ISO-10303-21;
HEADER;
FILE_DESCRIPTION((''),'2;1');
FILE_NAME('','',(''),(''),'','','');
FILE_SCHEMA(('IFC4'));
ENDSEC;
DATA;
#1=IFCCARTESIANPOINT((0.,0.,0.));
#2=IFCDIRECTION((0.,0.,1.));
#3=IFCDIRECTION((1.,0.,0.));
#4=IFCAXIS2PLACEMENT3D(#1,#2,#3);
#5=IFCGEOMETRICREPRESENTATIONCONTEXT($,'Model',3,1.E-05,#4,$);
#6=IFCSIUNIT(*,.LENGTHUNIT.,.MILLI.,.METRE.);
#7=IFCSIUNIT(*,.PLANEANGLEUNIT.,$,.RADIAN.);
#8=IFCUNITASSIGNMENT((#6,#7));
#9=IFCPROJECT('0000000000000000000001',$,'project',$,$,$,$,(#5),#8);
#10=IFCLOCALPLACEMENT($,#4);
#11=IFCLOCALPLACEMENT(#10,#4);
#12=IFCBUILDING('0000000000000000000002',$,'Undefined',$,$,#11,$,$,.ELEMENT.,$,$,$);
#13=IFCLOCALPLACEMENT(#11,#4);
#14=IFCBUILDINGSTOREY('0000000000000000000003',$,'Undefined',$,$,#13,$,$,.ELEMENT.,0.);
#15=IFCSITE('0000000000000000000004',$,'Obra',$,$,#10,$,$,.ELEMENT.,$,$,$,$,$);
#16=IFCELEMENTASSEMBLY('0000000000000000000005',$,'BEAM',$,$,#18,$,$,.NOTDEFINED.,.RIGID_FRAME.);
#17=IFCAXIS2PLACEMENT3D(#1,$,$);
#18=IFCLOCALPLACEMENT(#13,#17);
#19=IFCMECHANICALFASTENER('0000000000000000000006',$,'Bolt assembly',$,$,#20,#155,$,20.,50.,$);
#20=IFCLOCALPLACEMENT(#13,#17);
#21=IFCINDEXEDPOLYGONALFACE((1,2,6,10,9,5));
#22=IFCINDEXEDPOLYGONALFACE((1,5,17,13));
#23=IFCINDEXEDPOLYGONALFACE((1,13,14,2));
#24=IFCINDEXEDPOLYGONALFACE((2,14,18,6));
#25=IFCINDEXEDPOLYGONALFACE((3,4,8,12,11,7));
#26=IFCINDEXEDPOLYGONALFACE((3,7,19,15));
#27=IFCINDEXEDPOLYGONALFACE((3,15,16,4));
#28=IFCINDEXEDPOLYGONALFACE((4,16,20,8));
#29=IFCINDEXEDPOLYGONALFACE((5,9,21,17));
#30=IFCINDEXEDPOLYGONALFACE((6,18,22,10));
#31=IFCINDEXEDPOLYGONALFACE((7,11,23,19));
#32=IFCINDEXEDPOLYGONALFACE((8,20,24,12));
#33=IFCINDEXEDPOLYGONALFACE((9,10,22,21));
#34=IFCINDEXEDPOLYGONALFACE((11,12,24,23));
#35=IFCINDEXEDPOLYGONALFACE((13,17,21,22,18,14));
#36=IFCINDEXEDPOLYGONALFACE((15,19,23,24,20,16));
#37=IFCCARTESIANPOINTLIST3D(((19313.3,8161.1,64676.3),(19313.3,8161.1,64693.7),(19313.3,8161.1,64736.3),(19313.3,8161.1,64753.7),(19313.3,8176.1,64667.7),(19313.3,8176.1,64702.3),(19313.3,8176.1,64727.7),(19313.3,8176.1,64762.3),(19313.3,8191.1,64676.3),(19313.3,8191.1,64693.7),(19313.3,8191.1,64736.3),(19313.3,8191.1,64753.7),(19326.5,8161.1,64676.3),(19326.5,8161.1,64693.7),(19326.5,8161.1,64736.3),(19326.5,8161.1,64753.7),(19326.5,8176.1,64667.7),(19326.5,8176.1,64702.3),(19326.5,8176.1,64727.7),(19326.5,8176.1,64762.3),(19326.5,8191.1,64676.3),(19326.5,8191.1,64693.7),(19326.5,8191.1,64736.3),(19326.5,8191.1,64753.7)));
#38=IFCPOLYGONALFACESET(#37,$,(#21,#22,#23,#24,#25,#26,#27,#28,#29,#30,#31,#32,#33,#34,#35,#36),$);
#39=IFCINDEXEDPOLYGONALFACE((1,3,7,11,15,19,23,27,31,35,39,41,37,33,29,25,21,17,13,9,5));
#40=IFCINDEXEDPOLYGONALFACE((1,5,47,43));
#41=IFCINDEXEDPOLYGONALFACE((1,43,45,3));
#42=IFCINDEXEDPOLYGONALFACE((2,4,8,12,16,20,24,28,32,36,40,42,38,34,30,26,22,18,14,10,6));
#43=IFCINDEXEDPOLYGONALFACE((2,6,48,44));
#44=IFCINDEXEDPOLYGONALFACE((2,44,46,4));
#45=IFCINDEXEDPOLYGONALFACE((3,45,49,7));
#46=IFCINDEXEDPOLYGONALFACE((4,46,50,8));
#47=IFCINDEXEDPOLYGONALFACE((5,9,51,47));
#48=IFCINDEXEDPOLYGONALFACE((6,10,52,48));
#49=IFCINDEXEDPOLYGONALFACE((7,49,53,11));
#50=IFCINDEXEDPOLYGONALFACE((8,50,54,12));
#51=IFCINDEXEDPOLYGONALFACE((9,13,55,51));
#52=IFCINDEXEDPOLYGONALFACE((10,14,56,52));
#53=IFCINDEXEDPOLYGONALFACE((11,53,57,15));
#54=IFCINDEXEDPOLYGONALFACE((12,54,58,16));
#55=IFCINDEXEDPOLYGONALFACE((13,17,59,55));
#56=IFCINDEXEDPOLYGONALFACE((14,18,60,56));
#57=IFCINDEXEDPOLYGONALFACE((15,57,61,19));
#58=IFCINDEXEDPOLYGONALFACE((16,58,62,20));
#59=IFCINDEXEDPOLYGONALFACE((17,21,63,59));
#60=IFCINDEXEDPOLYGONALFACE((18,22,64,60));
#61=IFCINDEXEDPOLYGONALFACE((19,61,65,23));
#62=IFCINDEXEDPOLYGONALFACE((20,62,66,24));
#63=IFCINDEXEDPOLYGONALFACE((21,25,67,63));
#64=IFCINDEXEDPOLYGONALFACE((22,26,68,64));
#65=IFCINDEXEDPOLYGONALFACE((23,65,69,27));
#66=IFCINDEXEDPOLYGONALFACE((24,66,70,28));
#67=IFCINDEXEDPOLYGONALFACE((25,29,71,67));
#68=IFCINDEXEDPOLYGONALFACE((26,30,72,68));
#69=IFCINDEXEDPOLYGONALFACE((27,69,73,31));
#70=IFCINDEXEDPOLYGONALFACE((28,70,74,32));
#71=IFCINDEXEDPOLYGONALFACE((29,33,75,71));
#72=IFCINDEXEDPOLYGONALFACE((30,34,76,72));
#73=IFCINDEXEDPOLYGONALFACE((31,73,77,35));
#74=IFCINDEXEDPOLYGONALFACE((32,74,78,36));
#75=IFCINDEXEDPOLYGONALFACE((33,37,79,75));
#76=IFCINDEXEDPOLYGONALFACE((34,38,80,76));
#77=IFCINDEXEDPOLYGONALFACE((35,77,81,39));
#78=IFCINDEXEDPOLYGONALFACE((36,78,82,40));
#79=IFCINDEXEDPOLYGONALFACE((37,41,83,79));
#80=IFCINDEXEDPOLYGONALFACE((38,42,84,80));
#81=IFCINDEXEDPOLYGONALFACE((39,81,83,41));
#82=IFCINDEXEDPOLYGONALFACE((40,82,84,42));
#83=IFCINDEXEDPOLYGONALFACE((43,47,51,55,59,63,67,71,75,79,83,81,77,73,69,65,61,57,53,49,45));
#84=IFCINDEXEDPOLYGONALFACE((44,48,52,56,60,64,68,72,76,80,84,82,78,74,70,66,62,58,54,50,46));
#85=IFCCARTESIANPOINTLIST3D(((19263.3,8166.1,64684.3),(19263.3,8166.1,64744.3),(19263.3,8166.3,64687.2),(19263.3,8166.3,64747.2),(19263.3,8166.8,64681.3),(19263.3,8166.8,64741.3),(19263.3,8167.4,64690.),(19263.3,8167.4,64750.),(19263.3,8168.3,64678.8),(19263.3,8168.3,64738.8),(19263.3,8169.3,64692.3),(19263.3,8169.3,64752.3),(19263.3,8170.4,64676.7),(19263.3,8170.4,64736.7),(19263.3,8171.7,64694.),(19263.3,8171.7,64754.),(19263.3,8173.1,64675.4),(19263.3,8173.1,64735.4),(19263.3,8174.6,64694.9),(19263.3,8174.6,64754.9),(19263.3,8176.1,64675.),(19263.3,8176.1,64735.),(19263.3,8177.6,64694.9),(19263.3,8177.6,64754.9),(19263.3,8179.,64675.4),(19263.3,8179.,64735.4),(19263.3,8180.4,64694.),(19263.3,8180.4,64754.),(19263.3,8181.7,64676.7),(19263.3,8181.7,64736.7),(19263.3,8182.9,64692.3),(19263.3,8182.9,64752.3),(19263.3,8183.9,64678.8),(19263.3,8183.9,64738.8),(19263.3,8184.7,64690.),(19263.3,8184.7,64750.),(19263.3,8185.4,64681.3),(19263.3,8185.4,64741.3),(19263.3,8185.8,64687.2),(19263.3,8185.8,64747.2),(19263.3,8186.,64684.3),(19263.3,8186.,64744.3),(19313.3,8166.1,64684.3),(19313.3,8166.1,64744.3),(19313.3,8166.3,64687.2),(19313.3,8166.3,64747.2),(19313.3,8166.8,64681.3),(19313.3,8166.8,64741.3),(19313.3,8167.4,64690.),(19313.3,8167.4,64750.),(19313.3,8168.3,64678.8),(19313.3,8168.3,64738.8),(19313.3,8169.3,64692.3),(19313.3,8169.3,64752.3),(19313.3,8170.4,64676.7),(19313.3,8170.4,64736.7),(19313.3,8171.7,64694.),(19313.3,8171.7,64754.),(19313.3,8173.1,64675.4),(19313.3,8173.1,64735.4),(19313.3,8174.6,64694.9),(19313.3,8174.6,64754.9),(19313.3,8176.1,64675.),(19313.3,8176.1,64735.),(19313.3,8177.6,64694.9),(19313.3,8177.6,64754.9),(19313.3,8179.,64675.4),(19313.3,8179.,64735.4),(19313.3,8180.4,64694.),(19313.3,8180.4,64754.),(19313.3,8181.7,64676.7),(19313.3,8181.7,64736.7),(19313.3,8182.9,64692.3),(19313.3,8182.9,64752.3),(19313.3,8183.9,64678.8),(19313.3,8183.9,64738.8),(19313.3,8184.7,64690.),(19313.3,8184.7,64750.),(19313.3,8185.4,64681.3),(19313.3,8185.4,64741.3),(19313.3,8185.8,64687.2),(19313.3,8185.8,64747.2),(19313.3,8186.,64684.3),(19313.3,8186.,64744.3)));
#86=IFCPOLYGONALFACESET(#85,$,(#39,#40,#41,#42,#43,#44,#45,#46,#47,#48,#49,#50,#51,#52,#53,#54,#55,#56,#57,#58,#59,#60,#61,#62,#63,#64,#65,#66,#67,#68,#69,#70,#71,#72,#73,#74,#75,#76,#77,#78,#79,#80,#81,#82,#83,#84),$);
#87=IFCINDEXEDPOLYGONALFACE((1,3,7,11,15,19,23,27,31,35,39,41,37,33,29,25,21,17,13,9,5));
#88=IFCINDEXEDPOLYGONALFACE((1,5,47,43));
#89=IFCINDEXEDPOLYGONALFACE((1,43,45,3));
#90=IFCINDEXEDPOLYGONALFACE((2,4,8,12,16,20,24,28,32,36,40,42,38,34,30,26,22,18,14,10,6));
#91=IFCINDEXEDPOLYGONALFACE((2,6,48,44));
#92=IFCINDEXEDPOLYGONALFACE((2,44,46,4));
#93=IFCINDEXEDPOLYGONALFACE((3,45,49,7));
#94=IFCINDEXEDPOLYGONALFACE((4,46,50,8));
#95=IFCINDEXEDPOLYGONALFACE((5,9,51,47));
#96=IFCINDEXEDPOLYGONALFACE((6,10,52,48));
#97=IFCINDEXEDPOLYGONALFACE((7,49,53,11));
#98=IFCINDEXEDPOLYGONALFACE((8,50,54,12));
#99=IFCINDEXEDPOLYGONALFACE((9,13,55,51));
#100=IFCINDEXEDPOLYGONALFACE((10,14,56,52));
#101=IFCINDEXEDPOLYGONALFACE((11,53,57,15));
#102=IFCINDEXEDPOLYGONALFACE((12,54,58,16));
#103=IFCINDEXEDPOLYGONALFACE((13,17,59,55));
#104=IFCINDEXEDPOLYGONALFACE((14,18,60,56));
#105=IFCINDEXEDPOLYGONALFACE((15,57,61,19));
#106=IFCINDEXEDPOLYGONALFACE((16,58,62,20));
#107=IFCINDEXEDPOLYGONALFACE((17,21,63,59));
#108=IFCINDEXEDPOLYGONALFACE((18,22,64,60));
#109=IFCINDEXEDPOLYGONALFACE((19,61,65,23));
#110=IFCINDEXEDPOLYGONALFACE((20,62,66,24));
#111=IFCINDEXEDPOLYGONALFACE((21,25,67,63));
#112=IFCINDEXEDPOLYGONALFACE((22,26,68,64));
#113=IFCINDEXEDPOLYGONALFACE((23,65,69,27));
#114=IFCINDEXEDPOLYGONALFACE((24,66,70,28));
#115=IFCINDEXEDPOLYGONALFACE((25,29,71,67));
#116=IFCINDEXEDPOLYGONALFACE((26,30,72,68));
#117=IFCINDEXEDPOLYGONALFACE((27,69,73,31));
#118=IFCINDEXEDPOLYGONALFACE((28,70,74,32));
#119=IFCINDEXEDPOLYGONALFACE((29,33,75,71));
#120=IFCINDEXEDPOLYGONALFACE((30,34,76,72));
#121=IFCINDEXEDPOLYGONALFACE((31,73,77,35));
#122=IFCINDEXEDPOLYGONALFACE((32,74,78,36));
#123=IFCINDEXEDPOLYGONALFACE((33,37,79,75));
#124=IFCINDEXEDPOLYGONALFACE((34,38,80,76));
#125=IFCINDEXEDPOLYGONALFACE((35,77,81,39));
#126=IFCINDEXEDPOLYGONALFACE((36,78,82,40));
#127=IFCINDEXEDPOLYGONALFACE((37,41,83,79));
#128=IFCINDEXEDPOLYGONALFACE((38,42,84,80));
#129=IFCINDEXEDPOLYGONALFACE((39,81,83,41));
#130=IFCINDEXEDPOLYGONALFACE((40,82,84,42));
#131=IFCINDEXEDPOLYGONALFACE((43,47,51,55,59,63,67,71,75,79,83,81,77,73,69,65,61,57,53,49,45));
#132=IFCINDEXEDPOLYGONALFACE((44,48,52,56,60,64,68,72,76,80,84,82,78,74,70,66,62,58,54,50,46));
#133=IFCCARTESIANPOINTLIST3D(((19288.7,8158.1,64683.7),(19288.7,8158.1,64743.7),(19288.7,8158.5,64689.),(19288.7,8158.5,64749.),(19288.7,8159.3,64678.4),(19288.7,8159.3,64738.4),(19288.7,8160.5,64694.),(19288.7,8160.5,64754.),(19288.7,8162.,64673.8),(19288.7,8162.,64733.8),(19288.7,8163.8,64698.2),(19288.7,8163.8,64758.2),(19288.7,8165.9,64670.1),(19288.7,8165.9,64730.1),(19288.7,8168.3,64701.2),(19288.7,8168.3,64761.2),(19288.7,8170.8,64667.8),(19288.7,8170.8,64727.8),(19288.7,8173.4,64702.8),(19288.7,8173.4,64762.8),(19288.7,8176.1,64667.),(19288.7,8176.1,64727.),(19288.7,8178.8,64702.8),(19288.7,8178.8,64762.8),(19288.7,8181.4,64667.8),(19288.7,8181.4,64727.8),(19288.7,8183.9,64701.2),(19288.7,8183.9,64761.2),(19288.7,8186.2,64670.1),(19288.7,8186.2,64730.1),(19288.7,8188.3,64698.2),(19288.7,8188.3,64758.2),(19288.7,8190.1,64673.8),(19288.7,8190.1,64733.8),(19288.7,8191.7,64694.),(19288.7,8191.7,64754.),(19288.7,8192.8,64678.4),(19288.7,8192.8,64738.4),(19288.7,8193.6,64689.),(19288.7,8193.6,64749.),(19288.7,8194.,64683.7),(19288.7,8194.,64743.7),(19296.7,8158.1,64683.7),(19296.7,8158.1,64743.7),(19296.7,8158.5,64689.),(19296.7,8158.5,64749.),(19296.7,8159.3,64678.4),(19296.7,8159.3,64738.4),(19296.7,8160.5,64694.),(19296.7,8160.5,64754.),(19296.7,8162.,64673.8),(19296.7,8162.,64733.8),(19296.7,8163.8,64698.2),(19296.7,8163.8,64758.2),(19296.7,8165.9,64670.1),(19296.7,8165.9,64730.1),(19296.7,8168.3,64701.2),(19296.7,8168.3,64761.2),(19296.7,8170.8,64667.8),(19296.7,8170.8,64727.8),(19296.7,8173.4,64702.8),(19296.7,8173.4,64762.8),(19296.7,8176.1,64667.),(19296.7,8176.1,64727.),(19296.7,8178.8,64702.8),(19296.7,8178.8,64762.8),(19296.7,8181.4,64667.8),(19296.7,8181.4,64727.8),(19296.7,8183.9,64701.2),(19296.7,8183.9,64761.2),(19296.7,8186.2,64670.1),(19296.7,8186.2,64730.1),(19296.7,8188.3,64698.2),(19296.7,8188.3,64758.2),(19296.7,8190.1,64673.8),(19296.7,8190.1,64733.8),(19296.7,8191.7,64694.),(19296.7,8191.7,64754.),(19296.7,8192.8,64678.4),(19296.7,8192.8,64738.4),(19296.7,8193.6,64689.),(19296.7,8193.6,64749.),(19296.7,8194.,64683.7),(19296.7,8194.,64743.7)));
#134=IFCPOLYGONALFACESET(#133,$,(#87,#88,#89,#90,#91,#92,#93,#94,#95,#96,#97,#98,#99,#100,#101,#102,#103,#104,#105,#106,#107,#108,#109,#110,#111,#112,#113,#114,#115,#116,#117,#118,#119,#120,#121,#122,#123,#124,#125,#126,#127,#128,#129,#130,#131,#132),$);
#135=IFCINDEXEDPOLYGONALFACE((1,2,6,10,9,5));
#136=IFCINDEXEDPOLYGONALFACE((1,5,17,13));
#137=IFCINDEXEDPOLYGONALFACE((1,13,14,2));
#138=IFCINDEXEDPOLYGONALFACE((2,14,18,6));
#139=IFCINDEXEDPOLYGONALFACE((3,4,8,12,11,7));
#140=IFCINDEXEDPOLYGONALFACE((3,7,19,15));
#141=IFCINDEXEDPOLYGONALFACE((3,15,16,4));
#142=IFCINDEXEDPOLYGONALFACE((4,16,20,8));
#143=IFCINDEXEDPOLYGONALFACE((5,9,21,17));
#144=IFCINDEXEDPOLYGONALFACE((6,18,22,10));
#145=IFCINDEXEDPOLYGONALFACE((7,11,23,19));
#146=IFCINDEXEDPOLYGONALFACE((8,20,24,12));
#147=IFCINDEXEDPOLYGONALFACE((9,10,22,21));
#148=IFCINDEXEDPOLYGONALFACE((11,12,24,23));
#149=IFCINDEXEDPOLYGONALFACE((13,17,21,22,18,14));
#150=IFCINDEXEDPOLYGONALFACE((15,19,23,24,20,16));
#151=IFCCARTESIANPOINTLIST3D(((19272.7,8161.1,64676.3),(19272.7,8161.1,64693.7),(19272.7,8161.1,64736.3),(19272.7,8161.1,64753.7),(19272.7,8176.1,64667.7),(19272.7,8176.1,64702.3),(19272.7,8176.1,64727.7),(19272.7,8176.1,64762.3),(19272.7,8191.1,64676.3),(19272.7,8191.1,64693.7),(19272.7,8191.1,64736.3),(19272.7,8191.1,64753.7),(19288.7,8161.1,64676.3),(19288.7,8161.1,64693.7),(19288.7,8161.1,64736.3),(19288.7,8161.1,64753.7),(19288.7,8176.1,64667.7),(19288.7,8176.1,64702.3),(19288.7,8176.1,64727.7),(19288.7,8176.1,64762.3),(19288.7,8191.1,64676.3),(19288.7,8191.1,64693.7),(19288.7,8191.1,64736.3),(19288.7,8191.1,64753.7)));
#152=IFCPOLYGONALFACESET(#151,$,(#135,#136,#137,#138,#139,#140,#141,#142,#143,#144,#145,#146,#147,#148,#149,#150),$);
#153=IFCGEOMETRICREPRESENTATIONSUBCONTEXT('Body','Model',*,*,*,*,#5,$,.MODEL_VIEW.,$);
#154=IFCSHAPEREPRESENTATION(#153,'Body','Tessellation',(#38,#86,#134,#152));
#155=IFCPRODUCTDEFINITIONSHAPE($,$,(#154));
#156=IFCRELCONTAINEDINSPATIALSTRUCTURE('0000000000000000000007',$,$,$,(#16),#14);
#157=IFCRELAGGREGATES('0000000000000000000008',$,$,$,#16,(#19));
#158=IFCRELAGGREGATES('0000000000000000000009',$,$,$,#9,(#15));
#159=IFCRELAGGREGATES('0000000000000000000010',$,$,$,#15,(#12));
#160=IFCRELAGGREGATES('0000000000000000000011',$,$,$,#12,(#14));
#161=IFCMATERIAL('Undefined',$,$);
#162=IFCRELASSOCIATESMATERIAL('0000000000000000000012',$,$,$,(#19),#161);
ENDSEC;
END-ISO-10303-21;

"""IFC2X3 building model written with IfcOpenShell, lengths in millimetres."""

from ifc_helpers import new_model, si_unit, frame, origin_with_axes, origin_2d_with_axis, place, context, subcontext, project, spatial, polyline, circle, outline, extrude, source, transform, mapped, material, element, aggregate, save


model = new_model("IFC2X3")

# Units and contexts
model_context = context("Model", 3, precision=1e-05, world=origin_with_axes())
body_context = subcontext(model_context, "Body", "Model", "MODEL_VIEW")
ifc_project = project(units=[si_unit("LENGTHUNIT", "METRE", prefix="MILLI"), si_unit("PLANEANGLEUNIT", "RADIAN")], contexts=[model_context])

# Site, building, storey
site_placement = place(None, origin_with_axes())
site = spatial("IfcSite", under=ifc_project, at=site_placement, Name="Obra", CompositionType="ELEMENT")
building_placement = place(site_placement, origin_with_axes())
building = spatial("IfcBuilding", under=site, at=building_placement, Name="Undefined", CompositionType="ELEMENT")
storey_placement = place(building_placement, origin_with_axes())
storey = spatial("IfcBuildingStorey", under=building, at=storey_placement, Name="Undefined", CompositionType="ELEMENT", Elevation=0.0)

# Shared definitions
ifc_material = material(Name="Undefined")
shared_shape_1 = source(origin_with_axes(), body_context, "Body", "SweptSolid", [
    extrude(outline(polyline([(17.3, 0.0), (8.7, 15.0), (-8.7, 15.0), (-17.3, 0.0), (-8.7, -15.0), (8.7, -15.0), (17.3, 0.0)])), frame((0.0, -26.5, 0.0), z_axis=(0.0, 1.0, 0.0), x_axis=(1.0, 0.0, 0.0)), (0.0, 0.0, 1.0), 13.2),
    extrude(circle(Radius=10.0, at=origin_2d_with_axis()), frame((0.0, -13.3, 0.0), z_axis=(0.0, 1.0, 0.0), x_axis=(1.0, 0.0, 0.0)), (0.0, 0.0, 1.0), 50.0),
    extrude(circle(Radius=18.0, at=origin_2d_with_axis()), frame((0.0, 3.3, 0.0), z_axis=(0.0, 1.0, 0.0), x_axis=(1.0, 0.0, 0.0)), (0.0, 0.0, 1.0), 8.0),
    extrude(outline(polyline([(17.3, 0.0), (8.7, 15.0), (-8.7, 15.0), (-17.3, 0.0), (-8.7, -15.0), (8.7, -15.0), (17.3, 0.0)])), frame((0.0, 11.3, 0.0), z_axis=(0.0, 1.0, 0.0), x_axis=(1.0, 0.0, 0.0)), (0.0, 0.0, 1.0), 16.0),
])

# Element assembly
assembly_1_placement = place(storey_placement, origin_with_axes())
assembly_1 = element("IfcElementAssembly", 1, at=assembly_1_placement, inside=storey, Name="BEAM", AssemblyPlace="NOTDEFINED", PredefinedType="RIGID_FRAME")

# Mechanical fastener
mechanical_fastener_1_placement = place(assembly_1_placement, frame((19300.0, 8136.1, 64850.0), z_axis=(0.0, 1.0, 0.0), x_axis=(0.0, 0.0, -1.0)))
mechanical_fastener_1 = element("IfcMechanicalFastener", 2, at=mechanical_fastener_1_placement, material=ifc_material, Name="Bolt assembly", NominalDiameter=20.0, NominalLength=50.0, context=body_context, shape_type="MappedRepresentation", body=[
    mapped(shared_shape_1, transform((105.0, 0.0, 40.0))),
    mapped(shared_shape_1, transform((165.0, 0.0, 40.0))),
])
aggregate(assembly_1, [mechanical_fastener_1])

save(model, "model.ifc")
